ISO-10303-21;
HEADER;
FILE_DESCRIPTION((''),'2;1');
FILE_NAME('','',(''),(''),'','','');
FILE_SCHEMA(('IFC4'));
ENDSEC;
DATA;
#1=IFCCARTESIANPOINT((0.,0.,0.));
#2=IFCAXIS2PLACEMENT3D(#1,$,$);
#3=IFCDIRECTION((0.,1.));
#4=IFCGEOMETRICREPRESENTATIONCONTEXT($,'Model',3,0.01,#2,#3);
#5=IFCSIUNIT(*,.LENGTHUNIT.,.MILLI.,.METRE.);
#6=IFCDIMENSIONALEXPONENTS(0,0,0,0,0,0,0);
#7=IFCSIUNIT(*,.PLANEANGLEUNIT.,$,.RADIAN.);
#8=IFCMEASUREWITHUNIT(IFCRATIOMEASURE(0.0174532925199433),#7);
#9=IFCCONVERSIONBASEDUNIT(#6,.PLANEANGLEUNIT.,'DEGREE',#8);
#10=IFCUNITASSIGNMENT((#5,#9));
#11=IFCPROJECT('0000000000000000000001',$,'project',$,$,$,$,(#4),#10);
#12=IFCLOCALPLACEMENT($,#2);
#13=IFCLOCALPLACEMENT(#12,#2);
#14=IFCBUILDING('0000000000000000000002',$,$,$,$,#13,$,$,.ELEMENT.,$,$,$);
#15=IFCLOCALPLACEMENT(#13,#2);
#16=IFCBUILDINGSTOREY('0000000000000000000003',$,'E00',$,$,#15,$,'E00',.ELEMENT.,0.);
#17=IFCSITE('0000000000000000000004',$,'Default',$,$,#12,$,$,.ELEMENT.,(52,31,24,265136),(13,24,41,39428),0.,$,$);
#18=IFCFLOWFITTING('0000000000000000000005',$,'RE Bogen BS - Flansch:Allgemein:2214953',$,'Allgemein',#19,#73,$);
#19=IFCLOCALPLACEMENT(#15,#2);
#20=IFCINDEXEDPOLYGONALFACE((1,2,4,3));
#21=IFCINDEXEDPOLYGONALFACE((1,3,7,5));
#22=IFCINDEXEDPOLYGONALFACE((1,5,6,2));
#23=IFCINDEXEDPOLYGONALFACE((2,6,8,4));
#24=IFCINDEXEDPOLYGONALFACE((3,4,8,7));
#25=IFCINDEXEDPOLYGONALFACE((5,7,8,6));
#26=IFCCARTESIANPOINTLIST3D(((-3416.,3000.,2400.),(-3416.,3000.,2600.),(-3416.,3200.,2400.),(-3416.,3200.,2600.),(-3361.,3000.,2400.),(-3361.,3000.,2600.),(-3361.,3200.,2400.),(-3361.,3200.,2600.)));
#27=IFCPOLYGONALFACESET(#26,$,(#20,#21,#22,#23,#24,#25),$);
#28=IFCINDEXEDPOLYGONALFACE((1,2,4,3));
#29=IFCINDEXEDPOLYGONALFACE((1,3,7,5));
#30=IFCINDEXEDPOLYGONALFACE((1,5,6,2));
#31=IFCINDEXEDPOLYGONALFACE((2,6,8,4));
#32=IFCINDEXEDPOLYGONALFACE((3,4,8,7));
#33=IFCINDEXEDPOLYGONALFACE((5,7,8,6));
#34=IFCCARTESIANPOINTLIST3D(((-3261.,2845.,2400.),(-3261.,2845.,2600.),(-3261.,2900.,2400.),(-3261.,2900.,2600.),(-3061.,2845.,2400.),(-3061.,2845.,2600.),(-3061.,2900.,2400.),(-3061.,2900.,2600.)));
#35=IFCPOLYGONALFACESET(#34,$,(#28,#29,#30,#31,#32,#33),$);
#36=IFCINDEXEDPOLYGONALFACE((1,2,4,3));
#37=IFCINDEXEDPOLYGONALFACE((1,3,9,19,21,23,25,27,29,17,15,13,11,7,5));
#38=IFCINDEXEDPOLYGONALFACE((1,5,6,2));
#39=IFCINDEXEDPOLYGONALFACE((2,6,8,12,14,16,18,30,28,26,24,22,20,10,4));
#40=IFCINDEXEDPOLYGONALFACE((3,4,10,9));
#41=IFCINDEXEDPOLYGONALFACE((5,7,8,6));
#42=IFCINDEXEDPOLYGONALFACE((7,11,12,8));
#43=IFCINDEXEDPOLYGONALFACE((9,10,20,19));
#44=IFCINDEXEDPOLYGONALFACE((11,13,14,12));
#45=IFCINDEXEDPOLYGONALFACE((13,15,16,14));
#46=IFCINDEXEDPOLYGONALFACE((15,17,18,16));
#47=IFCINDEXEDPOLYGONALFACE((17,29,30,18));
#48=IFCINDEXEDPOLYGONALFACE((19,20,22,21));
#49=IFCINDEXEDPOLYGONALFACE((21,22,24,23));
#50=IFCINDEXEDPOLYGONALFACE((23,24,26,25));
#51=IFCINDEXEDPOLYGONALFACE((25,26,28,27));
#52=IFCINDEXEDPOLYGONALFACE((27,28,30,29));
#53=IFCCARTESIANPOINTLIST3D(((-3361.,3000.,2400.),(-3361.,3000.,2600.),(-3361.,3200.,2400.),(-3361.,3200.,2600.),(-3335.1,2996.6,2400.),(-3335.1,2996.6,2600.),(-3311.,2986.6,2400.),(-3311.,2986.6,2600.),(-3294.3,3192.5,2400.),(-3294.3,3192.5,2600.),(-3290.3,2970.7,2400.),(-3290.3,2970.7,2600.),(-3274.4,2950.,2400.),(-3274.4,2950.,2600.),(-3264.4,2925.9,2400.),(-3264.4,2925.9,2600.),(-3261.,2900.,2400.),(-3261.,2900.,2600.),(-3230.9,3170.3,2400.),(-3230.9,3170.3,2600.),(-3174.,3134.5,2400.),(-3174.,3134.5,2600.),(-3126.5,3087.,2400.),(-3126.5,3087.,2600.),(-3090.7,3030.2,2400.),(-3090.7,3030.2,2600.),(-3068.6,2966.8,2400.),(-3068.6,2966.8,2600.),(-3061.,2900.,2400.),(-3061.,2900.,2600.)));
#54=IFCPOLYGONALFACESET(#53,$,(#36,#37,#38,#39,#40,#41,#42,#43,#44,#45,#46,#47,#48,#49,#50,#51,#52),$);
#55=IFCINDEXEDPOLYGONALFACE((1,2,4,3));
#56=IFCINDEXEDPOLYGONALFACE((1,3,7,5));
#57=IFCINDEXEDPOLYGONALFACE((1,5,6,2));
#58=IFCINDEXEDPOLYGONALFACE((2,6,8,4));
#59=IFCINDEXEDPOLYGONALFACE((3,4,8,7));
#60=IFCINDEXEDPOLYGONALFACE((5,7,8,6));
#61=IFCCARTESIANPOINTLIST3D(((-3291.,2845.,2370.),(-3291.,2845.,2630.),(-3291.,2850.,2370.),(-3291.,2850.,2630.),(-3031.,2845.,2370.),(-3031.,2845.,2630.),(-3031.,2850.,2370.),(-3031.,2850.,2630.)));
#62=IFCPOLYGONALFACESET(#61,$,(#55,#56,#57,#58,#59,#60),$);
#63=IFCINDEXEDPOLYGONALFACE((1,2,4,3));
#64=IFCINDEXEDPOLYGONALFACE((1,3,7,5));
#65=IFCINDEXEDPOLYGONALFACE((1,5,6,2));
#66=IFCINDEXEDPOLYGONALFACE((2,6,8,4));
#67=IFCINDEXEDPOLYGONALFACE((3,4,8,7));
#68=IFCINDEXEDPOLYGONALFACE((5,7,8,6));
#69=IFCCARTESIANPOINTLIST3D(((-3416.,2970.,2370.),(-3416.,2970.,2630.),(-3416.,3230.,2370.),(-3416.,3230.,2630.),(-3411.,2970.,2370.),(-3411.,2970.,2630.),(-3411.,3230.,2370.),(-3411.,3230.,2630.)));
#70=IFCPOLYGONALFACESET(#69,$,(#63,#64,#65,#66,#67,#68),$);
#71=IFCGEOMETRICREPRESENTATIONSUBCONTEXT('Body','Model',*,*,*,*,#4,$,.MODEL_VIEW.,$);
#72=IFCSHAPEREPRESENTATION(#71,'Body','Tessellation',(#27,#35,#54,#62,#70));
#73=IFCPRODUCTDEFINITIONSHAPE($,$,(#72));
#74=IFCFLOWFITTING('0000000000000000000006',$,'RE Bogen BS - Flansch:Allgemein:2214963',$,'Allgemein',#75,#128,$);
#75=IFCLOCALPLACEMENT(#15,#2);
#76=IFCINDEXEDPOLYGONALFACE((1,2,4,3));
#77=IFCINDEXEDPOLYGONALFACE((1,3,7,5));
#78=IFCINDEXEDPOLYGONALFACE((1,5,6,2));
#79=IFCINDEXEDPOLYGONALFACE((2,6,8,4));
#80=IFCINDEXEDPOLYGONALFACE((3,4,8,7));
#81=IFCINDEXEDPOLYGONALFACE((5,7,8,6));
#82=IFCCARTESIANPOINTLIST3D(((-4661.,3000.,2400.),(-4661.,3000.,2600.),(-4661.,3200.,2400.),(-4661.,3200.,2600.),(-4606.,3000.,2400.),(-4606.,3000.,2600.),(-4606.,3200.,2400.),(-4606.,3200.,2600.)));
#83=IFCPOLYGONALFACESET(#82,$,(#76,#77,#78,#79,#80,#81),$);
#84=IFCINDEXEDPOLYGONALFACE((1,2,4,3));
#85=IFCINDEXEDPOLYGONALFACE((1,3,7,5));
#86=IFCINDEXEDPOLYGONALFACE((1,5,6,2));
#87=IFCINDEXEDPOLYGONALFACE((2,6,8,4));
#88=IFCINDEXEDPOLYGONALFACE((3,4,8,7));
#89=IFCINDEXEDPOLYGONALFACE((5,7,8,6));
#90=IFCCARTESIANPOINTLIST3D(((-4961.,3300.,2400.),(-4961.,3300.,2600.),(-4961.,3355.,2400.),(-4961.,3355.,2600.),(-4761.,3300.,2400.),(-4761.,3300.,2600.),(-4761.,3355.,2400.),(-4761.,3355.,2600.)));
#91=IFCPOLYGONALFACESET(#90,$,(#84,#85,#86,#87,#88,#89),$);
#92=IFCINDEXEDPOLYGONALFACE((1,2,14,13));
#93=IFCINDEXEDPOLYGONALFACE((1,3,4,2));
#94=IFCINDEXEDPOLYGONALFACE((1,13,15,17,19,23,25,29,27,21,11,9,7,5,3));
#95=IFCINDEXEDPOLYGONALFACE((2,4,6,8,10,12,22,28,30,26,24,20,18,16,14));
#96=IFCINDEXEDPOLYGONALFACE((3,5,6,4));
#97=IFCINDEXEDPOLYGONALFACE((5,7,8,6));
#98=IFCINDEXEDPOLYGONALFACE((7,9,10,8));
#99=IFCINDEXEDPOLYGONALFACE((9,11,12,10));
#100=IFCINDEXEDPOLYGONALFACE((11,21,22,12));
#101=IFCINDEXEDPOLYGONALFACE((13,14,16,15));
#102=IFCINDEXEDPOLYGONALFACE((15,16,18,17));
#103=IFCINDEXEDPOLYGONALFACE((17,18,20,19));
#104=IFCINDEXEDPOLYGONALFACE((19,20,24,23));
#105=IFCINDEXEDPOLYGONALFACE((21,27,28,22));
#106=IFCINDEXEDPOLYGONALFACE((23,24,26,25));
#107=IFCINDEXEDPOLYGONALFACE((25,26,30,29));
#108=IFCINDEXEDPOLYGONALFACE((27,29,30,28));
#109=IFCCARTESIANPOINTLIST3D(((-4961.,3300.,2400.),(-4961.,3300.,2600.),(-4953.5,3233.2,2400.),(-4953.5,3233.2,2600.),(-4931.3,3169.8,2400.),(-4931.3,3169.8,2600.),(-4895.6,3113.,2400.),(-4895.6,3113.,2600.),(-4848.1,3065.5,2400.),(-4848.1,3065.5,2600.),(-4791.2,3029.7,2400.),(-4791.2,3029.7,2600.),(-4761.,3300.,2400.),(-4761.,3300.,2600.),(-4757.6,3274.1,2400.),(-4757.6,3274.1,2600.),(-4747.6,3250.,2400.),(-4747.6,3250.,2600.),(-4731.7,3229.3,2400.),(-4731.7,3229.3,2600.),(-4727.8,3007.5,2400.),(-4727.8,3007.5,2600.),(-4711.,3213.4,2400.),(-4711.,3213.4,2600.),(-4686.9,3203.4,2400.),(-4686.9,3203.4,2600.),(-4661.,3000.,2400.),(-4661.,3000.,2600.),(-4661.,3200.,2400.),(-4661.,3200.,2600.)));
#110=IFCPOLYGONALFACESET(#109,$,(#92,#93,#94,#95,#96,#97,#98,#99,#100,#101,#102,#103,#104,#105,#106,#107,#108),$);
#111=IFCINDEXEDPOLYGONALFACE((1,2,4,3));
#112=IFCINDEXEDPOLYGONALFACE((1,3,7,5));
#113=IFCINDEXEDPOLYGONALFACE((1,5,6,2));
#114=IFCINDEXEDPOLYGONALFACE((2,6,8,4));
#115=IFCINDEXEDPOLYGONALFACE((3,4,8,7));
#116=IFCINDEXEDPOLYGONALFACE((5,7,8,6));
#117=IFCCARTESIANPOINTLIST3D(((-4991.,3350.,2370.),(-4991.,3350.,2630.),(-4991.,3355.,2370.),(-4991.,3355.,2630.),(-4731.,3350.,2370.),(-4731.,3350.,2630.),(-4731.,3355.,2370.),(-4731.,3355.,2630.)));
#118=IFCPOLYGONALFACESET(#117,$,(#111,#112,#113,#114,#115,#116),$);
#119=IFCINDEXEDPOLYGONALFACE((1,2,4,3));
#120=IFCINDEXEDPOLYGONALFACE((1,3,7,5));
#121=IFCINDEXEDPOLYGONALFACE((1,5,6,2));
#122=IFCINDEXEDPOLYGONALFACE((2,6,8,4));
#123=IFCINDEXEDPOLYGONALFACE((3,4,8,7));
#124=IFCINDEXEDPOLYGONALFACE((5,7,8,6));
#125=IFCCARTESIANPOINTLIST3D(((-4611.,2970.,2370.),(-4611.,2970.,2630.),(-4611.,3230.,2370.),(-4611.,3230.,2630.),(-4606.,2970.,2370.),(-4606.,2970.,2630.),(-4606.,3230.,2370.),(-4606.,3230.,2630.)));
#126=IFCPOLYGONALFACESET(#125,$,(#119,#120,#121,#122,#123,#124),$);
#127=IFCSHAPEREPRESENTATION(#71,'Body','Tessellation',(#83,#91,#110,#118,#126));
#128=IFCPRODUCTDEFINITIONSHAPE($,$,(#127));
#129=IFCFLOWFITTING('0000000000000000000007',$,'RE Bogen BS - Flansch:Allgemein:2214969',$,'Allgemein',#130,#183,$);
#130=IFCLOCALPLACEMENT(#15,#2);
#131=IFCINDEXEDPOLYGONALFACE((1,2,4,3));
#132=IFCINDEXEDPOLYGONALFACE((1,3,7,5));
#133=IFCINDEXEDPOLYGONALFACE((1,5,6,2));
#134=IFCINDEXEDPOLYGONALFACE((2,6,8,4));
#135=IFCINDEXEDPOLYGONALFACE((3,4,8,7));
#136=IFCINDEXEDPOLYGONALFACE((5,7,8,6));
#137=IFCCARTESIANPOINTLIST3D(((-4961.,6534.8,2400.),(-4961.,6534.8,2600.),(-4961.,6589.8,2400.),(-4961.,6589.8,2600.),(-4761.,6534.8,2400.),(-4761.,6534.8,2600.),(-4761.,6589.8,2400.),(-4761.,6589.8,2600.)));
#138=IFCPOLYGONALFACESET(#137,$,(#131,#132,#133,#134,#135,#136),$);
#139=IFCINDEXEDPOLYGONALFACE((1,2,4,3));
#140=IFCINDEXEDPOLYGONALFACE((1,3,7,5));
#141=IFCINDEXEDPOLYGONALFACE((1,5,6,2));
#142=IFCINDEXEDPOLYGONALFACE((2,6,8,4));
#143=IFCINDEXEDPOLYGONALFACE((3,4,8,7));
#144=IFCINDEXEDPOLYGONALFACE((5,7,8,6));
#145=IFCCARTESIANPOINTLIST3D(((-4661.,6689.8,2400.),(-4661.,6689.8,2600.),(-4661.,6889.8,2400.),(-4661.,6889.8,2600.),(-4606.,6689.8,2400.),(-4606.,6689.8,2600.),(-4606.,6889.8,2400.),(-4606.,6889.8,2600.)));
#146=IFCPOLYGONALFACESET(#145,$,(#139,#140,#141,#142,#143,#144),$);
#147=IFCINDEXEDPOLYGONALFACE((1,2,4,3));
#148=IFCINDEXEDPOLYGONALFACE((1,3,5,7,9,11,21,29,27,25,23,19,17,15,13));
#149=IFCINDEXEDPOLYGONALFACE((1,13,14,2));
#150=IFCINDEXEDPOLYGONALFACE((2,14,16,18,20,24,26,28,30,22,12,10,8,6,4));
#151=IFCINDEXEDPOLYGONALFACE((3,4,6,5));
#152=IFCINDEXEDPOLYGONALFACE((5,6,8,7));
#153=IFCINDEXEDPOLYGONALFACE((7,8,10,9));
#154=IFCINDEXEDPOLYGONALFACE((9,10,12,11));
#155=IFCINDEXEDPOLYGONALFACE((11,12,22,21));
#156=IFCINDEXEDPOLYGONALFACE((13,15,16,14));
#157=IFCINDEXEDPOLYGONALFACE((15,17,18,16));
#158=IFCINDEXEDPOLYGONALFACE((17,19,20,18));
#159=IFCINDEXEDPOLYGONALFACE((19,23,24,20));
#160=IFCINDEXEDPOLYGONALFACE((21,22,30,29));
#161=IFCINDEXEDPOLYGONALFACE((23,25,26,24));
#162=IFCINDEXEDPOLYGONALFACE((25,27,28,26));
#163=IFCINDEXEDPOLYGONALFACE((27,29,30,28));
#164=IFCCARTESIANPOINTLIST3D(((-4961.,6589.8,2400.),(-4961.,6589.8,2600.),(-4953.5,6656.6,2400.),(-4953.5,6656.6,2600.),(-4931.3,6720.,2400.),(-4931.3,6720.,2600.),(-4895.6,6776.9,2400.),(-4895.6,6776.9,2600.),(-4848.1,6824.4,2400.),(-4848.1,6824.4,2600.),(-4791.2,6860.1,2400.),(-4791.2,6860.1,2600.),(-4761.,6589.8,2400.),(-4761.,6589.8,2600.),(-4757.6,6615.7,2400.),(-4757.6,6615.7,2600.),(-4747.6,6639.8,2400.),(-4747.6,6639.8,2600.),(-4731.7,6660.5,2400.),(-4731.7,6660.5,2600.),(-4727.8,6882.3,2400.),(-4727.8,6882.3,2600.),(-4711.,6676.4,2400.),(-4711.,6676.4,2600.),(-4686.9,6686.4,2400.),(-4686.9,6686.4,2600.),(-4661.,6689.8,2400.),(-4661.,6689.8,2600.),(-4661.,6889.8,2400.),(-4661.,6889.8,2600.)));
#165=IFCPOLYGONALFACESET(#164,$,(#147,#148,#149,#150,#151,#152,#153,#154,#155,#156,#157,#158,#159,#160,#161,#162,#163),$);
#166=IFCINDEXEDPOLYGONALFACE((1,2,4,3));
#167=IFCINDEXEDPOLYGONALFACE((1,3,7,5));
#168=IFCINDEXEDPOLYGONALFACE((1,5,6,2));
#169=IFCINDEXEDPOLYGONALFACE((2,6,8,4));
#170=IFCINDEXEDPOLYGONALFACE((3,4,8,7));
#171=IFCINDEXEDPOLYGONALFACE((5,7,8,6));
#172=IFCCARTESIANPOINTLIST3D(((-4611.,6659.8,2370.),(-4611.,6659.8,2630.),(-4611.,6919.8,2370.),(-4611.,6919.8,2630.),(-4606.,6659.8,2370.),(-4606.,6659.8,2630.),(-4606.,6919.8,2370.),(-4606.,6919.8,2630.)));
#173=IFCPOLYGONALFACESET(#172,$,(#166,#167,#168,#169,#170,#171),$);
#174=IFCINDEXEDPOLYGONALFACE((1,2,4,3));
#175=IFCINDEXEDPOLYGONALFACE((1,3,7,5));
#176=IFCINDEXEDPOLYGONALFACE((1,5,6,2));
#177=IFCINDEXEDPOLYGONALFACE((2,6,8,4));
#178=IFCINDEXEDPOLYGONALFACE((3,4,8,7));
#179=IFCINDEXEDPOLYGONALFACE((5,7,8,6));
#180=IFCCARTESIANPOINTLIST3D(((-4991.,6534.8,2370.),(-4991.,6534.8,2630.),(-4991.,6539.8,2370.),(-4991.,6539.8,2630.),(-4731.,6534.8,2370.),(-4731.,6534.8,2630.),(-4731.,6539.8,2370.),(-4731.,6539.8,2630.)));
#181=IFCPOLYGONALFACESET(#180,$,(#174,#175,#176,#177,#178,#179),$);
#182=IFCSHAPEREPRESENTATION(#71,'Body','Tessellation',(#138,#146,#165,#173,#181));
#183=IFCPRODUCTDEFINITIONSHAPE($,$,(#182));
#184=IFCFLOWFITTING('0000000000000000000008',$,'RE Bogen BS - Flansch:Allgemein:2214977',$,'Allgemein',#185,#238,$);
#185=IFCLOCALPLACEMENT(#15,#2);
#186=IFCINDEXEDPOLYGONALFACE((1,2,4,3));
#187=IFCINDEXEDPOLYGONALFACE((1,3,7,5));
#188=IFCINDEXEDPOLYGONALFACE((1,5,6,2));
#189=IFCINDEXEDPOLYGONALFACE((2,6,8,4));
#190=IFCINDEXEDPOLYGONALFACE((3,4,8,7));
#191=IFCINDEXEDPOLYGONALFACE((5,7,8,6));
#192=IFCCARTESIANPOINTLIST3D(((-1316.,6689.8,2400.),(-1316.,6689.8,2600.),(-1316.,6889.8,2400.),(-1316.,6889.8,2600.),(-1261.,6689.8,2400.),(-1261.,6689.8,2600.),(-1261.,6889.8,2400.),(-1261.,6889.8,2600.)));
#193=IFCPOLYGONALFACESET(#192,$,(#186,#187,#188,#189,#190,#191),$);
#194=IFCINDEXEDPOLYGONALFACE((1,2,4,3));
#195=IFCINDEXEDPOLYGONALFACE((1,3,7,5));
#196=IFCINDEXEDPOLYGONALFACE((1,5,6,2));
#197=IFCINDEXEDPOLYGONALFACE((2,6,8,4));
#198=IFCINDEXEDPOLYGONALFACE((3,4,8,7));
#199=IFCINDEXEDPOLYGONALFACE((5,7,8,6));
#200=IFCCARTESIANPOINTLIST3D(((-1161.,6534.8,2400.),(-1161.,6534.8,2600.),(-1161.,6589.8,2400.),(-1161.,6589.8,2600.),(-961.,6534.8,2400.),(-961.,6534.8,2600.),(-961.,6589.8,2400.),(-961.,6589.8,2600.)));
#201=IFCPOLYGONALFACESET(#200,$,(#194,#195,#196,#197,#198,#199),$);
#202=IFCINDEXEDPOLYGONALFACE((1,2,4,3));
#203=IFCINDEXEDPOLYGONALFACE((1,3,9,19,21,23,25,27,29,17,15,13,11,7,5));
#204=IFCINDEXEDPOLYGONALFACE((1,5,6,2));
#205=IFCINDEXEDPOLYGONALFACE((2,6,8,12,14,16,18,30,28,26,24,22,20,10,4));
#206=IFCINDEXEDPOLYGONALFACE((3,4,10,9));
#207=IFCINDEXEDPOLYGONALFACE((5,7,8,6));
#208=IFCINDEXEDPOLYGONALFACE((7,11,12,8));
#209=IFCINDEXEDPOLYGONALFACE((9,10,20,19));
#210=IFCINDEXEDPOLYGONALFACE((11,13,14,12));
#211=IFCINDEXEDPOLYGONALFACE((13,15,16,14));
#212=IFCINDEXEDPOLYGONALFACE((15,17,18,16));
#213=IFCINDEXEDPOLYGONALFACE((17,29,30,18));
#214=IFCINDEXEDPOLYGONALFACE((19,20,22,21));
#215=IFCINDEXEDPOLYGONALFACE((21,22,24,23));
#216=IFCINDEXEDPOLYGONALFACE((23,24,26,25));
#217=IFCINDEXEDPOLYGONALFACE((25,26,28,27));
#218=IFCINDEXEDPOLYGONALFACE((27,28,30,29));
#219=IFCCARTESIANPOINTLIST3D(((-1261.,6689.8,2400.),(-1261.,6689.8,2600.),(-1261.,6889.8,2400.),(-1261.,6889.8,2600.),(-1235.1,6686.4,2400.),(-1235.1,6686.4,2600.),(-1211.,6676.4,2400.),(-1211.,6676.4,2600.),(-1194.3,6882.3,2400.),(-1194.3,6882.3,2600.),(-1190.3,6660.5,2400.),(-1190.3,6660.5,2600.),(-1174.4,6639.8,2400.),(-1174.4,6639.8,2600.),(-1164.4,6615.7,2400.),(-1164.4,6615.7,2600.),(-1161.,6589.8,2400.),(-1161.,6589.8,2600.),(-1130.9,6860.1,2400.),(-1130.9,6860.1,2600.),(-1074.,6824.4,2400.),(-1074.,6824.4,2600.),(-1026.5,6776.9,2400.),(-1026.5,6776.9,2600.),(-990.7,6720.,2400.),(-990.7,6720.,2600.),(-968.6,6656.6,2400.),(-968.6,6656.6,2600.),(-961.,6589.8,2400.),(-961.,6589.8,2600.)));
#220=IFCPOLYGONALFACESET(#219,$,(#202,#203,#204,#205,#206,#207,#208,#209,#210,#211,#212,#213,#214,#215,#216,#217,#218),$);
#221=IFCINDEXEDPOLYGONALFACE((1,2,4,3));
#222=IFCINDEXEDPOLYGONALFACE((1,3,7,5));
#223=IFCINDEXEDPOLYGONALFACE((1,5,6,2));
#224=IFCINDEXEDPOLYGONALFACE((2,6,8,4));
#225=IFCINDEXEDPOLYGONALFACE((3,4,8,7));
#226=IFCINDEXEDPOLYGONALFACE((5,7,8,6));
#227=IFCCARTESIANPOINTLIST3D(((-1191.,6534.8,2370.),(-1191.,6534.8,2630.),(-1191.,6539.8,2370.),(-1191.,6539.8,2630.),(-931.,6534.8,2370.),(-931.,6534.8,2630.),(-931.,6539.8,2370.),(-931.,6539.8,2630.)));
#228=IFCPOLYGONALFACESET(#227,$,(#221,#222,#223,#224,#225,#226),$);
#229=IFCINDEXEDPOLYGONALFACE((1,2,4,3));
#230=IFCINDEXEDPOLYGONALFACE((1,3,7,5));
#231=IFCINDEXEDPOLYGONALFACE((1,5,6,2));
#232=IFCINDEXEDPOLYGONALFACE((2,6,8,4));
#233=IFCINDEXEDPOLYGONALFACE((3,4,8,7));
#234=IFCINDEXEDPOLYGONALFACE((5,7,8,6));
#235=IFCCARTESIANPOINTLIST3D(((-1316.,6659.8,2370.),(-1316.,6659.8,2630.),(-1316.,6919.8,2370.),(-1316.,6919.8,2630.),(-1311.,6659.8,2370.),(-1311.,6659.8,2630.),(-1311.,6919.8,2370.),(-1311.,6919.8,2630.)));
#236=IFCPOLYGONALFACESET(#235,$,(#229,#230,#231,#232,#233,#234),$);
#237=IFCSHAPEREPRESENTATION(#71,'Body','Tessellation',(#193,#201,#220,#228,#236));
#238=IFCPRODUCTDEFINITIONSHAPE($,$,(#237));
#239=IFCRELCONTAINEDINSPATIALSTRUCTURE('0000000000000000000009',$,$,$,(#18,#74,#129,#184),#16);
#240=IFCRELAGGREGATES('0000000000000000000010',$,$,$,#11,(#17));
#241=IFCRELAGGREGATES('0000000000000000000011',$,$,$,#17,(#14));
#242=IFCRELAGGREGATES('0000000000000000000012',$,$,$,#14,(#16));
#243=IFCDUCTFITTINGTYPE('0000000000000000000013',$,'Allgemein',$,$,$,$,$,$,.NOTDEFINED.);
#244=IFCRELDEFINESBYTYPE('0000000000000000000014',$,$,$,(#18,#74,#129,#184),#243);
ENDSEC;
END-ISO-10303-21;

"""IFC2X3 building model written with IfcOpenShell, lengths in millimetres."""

from ifc_helpers import new_model, entity, si_unit, converted_unit, direction, frame, frame_2d, origin, place, context, subcontext, project, spatial, polyline, circle_curve, parameter, trimmed, segment, composite_curve, rectangle, outline, extrude, source, transform, mapped, type_object, type_shapes, element, save


model = new_model("IFC2X3")

# Units and contexts
model_context = context("Model", 3, precision=0.01, world=origin(), true_north=direction((0.0, 1.0)))
body_context = subcontext(model_context, "Body", "Model", "MODEL_VIEW")
ifc_project = project(units=[si_unit("LENGTHUNIT", "METRE", prefix="MILLI"), converted_unit("PLANEANGLEUNIT", "DEGREE", entity("IfcRatioMeasure", 0.0174532925199433), si_unit("PLANEANGLEUNIT", "RADIAN"), dimensions=[0, 0, 0, 0, 0, 0, 0])], contexts=[model_context])

# Site, building, storey
site_placement = place(None, origin())
site = spatial("IfcSite", under=ifc_project, at=site_placement, Name="Default", CompositionType="ELEMENT", RefLatitude=(52, 31, 24, 265136), RefLongitude=(13, 24, 41, 39428), RefElevation=0.0)
building_placement = place(site_placement, origin())
building = spatial("IfcBuilding", under=site, at=building_placement, CompositionType="ELEMENT")
storey_placement = place(building_placement, origin())
storey = spatial("IfcBuildingStorey", under=building, at=storey_placement, Name="E00", LongName="E00", CompositionType="ELEMENT", Elevation=0.0)

# Flow fittings
duct_fitting_type = type_object("IfcDuctFittingType", Name="Allgemein", PredefinedType="NOTDEFINED")
shared_shape = source(origin(), body_context, "Body", "SweptSolid", [
    extrude(rectangle(XDim=55.0, YDim=200.0, at=frame_2d((0.0, 0.0), x_axis=(1.0, 0.0))), frame((0.0, 227.5, -100.0), z_axis=(0.0, 0.0, 1.0), x_axis=(0.0, 1.0, 0.0)), (0.0, 0.0, 1.0), 200.0),
    extrude(rectangle(XDim=200.0, YDim=55.0, at=frame_2d((0.0, 0.0), x_axis=(1.0, 0.0))), frame((-227.5, 0.0, -100.0), z_axis=(0.0, 0.0, 1.0), x_axis=(0.0, -1.0, 0.0)), (0.0, 0.0, 1.0), 200.0),
    extrude(outline(composite_curve([segment(polyline([(-200.0, -100.0), (0.0, -100.0)]), True, "CONTINUOUS"), segment(trimmed(circle_curve(frame_2d((100.0, -100.0), x_axis=(0.0, 1.0)), 100.0), [parameter(0.0)], [parameter(90.0)], True, "PARAMETER"), False, "CONTINUOUS"), segment(polyline([(100.0, 0.0), (100.0, 200.0)]), True, "CONTINUOUS"), segment(trimmed(circle_curve(frame_2d((100.0, -100.0), x_axis=(0.0, 1.0)), 300.0), [parameter(0.0)], [parameter(90.0)], True, "PARAMETER"), True, "CONTINUOUS")], self_intersect=False)), frame((-100.0, 100.0, -100.0), z_axis=(0.0, 0.0, 1.0), x_axis=(-1.0, 0.0, 0.0)), (0.0, 0.0, 1.0), 200.0),
    extrude(rectangle(XDim=5.0, YDim=260.0, at=frame_2d((0.0, 0.0), x_axis=(1.0, 0.0))), frame((-252.5, 0.0, -130.0)), (0.0, 0.0, 1.0), 260.0),
    extrude(rectangle(XDim=5.0, YDim=260.0, at=frame_2d((0.0, 0.0), x_axis=(1.0, 0.0))), frame((0.0, 252.5, -130.0), z_axis=(0.0, 0.0, 1.0), x_axis=(0.0, 1.0, 0.0)), (0.0, 0.0, 1.0), 260.0),
])
type_shapes(duct_fitting_type, [shared_shape])
for number, where, z_axis, x_axis, name in (
    (1, (-3161.0, 3100.0, 2500.0), (0.0, 0.0, 1.0), (0.0, 1.0, 0.0), "RE Bogen BS - Flansch:Allgemein:2214953"),
    (2, (-4861.0, 3100.0, 2500.0), (0.0, 0.0, 1.0), (0.0, -1.0, 0.0), "RE Bogen BS - Flansch:Allgemein:2214963"),
    (3, (-4861.0, 6789.8, 2500.0), (0.0, 0.0, 1.0), (-1.0, 0.0, 0.0), "RE Bogen BS - Flansch:Allgemein:2214969"),
    (4, (-1061.0, 6789.8, 2500.0), (0.0, 0.0, 1.0), (0.0, 1.0, 0.0), "RE Bogen BS - Flansch:Allgemein:2214977"),
):
    element("IfcFlowFitting", number, at=place(storey_placement, frame(where, z_axis=z_axis, x_axis=x_axis)), inside=storey, type_object=duct_fitting_type, Name=name, ObjectType="Allgemein", context=body_context, shape_type="MappedRepresentation", body=[
        mapped(shared_shape, transform((0.0, 0.0, 0.0), scale=1.0)),
    ])

save(model, "model.ifc")
